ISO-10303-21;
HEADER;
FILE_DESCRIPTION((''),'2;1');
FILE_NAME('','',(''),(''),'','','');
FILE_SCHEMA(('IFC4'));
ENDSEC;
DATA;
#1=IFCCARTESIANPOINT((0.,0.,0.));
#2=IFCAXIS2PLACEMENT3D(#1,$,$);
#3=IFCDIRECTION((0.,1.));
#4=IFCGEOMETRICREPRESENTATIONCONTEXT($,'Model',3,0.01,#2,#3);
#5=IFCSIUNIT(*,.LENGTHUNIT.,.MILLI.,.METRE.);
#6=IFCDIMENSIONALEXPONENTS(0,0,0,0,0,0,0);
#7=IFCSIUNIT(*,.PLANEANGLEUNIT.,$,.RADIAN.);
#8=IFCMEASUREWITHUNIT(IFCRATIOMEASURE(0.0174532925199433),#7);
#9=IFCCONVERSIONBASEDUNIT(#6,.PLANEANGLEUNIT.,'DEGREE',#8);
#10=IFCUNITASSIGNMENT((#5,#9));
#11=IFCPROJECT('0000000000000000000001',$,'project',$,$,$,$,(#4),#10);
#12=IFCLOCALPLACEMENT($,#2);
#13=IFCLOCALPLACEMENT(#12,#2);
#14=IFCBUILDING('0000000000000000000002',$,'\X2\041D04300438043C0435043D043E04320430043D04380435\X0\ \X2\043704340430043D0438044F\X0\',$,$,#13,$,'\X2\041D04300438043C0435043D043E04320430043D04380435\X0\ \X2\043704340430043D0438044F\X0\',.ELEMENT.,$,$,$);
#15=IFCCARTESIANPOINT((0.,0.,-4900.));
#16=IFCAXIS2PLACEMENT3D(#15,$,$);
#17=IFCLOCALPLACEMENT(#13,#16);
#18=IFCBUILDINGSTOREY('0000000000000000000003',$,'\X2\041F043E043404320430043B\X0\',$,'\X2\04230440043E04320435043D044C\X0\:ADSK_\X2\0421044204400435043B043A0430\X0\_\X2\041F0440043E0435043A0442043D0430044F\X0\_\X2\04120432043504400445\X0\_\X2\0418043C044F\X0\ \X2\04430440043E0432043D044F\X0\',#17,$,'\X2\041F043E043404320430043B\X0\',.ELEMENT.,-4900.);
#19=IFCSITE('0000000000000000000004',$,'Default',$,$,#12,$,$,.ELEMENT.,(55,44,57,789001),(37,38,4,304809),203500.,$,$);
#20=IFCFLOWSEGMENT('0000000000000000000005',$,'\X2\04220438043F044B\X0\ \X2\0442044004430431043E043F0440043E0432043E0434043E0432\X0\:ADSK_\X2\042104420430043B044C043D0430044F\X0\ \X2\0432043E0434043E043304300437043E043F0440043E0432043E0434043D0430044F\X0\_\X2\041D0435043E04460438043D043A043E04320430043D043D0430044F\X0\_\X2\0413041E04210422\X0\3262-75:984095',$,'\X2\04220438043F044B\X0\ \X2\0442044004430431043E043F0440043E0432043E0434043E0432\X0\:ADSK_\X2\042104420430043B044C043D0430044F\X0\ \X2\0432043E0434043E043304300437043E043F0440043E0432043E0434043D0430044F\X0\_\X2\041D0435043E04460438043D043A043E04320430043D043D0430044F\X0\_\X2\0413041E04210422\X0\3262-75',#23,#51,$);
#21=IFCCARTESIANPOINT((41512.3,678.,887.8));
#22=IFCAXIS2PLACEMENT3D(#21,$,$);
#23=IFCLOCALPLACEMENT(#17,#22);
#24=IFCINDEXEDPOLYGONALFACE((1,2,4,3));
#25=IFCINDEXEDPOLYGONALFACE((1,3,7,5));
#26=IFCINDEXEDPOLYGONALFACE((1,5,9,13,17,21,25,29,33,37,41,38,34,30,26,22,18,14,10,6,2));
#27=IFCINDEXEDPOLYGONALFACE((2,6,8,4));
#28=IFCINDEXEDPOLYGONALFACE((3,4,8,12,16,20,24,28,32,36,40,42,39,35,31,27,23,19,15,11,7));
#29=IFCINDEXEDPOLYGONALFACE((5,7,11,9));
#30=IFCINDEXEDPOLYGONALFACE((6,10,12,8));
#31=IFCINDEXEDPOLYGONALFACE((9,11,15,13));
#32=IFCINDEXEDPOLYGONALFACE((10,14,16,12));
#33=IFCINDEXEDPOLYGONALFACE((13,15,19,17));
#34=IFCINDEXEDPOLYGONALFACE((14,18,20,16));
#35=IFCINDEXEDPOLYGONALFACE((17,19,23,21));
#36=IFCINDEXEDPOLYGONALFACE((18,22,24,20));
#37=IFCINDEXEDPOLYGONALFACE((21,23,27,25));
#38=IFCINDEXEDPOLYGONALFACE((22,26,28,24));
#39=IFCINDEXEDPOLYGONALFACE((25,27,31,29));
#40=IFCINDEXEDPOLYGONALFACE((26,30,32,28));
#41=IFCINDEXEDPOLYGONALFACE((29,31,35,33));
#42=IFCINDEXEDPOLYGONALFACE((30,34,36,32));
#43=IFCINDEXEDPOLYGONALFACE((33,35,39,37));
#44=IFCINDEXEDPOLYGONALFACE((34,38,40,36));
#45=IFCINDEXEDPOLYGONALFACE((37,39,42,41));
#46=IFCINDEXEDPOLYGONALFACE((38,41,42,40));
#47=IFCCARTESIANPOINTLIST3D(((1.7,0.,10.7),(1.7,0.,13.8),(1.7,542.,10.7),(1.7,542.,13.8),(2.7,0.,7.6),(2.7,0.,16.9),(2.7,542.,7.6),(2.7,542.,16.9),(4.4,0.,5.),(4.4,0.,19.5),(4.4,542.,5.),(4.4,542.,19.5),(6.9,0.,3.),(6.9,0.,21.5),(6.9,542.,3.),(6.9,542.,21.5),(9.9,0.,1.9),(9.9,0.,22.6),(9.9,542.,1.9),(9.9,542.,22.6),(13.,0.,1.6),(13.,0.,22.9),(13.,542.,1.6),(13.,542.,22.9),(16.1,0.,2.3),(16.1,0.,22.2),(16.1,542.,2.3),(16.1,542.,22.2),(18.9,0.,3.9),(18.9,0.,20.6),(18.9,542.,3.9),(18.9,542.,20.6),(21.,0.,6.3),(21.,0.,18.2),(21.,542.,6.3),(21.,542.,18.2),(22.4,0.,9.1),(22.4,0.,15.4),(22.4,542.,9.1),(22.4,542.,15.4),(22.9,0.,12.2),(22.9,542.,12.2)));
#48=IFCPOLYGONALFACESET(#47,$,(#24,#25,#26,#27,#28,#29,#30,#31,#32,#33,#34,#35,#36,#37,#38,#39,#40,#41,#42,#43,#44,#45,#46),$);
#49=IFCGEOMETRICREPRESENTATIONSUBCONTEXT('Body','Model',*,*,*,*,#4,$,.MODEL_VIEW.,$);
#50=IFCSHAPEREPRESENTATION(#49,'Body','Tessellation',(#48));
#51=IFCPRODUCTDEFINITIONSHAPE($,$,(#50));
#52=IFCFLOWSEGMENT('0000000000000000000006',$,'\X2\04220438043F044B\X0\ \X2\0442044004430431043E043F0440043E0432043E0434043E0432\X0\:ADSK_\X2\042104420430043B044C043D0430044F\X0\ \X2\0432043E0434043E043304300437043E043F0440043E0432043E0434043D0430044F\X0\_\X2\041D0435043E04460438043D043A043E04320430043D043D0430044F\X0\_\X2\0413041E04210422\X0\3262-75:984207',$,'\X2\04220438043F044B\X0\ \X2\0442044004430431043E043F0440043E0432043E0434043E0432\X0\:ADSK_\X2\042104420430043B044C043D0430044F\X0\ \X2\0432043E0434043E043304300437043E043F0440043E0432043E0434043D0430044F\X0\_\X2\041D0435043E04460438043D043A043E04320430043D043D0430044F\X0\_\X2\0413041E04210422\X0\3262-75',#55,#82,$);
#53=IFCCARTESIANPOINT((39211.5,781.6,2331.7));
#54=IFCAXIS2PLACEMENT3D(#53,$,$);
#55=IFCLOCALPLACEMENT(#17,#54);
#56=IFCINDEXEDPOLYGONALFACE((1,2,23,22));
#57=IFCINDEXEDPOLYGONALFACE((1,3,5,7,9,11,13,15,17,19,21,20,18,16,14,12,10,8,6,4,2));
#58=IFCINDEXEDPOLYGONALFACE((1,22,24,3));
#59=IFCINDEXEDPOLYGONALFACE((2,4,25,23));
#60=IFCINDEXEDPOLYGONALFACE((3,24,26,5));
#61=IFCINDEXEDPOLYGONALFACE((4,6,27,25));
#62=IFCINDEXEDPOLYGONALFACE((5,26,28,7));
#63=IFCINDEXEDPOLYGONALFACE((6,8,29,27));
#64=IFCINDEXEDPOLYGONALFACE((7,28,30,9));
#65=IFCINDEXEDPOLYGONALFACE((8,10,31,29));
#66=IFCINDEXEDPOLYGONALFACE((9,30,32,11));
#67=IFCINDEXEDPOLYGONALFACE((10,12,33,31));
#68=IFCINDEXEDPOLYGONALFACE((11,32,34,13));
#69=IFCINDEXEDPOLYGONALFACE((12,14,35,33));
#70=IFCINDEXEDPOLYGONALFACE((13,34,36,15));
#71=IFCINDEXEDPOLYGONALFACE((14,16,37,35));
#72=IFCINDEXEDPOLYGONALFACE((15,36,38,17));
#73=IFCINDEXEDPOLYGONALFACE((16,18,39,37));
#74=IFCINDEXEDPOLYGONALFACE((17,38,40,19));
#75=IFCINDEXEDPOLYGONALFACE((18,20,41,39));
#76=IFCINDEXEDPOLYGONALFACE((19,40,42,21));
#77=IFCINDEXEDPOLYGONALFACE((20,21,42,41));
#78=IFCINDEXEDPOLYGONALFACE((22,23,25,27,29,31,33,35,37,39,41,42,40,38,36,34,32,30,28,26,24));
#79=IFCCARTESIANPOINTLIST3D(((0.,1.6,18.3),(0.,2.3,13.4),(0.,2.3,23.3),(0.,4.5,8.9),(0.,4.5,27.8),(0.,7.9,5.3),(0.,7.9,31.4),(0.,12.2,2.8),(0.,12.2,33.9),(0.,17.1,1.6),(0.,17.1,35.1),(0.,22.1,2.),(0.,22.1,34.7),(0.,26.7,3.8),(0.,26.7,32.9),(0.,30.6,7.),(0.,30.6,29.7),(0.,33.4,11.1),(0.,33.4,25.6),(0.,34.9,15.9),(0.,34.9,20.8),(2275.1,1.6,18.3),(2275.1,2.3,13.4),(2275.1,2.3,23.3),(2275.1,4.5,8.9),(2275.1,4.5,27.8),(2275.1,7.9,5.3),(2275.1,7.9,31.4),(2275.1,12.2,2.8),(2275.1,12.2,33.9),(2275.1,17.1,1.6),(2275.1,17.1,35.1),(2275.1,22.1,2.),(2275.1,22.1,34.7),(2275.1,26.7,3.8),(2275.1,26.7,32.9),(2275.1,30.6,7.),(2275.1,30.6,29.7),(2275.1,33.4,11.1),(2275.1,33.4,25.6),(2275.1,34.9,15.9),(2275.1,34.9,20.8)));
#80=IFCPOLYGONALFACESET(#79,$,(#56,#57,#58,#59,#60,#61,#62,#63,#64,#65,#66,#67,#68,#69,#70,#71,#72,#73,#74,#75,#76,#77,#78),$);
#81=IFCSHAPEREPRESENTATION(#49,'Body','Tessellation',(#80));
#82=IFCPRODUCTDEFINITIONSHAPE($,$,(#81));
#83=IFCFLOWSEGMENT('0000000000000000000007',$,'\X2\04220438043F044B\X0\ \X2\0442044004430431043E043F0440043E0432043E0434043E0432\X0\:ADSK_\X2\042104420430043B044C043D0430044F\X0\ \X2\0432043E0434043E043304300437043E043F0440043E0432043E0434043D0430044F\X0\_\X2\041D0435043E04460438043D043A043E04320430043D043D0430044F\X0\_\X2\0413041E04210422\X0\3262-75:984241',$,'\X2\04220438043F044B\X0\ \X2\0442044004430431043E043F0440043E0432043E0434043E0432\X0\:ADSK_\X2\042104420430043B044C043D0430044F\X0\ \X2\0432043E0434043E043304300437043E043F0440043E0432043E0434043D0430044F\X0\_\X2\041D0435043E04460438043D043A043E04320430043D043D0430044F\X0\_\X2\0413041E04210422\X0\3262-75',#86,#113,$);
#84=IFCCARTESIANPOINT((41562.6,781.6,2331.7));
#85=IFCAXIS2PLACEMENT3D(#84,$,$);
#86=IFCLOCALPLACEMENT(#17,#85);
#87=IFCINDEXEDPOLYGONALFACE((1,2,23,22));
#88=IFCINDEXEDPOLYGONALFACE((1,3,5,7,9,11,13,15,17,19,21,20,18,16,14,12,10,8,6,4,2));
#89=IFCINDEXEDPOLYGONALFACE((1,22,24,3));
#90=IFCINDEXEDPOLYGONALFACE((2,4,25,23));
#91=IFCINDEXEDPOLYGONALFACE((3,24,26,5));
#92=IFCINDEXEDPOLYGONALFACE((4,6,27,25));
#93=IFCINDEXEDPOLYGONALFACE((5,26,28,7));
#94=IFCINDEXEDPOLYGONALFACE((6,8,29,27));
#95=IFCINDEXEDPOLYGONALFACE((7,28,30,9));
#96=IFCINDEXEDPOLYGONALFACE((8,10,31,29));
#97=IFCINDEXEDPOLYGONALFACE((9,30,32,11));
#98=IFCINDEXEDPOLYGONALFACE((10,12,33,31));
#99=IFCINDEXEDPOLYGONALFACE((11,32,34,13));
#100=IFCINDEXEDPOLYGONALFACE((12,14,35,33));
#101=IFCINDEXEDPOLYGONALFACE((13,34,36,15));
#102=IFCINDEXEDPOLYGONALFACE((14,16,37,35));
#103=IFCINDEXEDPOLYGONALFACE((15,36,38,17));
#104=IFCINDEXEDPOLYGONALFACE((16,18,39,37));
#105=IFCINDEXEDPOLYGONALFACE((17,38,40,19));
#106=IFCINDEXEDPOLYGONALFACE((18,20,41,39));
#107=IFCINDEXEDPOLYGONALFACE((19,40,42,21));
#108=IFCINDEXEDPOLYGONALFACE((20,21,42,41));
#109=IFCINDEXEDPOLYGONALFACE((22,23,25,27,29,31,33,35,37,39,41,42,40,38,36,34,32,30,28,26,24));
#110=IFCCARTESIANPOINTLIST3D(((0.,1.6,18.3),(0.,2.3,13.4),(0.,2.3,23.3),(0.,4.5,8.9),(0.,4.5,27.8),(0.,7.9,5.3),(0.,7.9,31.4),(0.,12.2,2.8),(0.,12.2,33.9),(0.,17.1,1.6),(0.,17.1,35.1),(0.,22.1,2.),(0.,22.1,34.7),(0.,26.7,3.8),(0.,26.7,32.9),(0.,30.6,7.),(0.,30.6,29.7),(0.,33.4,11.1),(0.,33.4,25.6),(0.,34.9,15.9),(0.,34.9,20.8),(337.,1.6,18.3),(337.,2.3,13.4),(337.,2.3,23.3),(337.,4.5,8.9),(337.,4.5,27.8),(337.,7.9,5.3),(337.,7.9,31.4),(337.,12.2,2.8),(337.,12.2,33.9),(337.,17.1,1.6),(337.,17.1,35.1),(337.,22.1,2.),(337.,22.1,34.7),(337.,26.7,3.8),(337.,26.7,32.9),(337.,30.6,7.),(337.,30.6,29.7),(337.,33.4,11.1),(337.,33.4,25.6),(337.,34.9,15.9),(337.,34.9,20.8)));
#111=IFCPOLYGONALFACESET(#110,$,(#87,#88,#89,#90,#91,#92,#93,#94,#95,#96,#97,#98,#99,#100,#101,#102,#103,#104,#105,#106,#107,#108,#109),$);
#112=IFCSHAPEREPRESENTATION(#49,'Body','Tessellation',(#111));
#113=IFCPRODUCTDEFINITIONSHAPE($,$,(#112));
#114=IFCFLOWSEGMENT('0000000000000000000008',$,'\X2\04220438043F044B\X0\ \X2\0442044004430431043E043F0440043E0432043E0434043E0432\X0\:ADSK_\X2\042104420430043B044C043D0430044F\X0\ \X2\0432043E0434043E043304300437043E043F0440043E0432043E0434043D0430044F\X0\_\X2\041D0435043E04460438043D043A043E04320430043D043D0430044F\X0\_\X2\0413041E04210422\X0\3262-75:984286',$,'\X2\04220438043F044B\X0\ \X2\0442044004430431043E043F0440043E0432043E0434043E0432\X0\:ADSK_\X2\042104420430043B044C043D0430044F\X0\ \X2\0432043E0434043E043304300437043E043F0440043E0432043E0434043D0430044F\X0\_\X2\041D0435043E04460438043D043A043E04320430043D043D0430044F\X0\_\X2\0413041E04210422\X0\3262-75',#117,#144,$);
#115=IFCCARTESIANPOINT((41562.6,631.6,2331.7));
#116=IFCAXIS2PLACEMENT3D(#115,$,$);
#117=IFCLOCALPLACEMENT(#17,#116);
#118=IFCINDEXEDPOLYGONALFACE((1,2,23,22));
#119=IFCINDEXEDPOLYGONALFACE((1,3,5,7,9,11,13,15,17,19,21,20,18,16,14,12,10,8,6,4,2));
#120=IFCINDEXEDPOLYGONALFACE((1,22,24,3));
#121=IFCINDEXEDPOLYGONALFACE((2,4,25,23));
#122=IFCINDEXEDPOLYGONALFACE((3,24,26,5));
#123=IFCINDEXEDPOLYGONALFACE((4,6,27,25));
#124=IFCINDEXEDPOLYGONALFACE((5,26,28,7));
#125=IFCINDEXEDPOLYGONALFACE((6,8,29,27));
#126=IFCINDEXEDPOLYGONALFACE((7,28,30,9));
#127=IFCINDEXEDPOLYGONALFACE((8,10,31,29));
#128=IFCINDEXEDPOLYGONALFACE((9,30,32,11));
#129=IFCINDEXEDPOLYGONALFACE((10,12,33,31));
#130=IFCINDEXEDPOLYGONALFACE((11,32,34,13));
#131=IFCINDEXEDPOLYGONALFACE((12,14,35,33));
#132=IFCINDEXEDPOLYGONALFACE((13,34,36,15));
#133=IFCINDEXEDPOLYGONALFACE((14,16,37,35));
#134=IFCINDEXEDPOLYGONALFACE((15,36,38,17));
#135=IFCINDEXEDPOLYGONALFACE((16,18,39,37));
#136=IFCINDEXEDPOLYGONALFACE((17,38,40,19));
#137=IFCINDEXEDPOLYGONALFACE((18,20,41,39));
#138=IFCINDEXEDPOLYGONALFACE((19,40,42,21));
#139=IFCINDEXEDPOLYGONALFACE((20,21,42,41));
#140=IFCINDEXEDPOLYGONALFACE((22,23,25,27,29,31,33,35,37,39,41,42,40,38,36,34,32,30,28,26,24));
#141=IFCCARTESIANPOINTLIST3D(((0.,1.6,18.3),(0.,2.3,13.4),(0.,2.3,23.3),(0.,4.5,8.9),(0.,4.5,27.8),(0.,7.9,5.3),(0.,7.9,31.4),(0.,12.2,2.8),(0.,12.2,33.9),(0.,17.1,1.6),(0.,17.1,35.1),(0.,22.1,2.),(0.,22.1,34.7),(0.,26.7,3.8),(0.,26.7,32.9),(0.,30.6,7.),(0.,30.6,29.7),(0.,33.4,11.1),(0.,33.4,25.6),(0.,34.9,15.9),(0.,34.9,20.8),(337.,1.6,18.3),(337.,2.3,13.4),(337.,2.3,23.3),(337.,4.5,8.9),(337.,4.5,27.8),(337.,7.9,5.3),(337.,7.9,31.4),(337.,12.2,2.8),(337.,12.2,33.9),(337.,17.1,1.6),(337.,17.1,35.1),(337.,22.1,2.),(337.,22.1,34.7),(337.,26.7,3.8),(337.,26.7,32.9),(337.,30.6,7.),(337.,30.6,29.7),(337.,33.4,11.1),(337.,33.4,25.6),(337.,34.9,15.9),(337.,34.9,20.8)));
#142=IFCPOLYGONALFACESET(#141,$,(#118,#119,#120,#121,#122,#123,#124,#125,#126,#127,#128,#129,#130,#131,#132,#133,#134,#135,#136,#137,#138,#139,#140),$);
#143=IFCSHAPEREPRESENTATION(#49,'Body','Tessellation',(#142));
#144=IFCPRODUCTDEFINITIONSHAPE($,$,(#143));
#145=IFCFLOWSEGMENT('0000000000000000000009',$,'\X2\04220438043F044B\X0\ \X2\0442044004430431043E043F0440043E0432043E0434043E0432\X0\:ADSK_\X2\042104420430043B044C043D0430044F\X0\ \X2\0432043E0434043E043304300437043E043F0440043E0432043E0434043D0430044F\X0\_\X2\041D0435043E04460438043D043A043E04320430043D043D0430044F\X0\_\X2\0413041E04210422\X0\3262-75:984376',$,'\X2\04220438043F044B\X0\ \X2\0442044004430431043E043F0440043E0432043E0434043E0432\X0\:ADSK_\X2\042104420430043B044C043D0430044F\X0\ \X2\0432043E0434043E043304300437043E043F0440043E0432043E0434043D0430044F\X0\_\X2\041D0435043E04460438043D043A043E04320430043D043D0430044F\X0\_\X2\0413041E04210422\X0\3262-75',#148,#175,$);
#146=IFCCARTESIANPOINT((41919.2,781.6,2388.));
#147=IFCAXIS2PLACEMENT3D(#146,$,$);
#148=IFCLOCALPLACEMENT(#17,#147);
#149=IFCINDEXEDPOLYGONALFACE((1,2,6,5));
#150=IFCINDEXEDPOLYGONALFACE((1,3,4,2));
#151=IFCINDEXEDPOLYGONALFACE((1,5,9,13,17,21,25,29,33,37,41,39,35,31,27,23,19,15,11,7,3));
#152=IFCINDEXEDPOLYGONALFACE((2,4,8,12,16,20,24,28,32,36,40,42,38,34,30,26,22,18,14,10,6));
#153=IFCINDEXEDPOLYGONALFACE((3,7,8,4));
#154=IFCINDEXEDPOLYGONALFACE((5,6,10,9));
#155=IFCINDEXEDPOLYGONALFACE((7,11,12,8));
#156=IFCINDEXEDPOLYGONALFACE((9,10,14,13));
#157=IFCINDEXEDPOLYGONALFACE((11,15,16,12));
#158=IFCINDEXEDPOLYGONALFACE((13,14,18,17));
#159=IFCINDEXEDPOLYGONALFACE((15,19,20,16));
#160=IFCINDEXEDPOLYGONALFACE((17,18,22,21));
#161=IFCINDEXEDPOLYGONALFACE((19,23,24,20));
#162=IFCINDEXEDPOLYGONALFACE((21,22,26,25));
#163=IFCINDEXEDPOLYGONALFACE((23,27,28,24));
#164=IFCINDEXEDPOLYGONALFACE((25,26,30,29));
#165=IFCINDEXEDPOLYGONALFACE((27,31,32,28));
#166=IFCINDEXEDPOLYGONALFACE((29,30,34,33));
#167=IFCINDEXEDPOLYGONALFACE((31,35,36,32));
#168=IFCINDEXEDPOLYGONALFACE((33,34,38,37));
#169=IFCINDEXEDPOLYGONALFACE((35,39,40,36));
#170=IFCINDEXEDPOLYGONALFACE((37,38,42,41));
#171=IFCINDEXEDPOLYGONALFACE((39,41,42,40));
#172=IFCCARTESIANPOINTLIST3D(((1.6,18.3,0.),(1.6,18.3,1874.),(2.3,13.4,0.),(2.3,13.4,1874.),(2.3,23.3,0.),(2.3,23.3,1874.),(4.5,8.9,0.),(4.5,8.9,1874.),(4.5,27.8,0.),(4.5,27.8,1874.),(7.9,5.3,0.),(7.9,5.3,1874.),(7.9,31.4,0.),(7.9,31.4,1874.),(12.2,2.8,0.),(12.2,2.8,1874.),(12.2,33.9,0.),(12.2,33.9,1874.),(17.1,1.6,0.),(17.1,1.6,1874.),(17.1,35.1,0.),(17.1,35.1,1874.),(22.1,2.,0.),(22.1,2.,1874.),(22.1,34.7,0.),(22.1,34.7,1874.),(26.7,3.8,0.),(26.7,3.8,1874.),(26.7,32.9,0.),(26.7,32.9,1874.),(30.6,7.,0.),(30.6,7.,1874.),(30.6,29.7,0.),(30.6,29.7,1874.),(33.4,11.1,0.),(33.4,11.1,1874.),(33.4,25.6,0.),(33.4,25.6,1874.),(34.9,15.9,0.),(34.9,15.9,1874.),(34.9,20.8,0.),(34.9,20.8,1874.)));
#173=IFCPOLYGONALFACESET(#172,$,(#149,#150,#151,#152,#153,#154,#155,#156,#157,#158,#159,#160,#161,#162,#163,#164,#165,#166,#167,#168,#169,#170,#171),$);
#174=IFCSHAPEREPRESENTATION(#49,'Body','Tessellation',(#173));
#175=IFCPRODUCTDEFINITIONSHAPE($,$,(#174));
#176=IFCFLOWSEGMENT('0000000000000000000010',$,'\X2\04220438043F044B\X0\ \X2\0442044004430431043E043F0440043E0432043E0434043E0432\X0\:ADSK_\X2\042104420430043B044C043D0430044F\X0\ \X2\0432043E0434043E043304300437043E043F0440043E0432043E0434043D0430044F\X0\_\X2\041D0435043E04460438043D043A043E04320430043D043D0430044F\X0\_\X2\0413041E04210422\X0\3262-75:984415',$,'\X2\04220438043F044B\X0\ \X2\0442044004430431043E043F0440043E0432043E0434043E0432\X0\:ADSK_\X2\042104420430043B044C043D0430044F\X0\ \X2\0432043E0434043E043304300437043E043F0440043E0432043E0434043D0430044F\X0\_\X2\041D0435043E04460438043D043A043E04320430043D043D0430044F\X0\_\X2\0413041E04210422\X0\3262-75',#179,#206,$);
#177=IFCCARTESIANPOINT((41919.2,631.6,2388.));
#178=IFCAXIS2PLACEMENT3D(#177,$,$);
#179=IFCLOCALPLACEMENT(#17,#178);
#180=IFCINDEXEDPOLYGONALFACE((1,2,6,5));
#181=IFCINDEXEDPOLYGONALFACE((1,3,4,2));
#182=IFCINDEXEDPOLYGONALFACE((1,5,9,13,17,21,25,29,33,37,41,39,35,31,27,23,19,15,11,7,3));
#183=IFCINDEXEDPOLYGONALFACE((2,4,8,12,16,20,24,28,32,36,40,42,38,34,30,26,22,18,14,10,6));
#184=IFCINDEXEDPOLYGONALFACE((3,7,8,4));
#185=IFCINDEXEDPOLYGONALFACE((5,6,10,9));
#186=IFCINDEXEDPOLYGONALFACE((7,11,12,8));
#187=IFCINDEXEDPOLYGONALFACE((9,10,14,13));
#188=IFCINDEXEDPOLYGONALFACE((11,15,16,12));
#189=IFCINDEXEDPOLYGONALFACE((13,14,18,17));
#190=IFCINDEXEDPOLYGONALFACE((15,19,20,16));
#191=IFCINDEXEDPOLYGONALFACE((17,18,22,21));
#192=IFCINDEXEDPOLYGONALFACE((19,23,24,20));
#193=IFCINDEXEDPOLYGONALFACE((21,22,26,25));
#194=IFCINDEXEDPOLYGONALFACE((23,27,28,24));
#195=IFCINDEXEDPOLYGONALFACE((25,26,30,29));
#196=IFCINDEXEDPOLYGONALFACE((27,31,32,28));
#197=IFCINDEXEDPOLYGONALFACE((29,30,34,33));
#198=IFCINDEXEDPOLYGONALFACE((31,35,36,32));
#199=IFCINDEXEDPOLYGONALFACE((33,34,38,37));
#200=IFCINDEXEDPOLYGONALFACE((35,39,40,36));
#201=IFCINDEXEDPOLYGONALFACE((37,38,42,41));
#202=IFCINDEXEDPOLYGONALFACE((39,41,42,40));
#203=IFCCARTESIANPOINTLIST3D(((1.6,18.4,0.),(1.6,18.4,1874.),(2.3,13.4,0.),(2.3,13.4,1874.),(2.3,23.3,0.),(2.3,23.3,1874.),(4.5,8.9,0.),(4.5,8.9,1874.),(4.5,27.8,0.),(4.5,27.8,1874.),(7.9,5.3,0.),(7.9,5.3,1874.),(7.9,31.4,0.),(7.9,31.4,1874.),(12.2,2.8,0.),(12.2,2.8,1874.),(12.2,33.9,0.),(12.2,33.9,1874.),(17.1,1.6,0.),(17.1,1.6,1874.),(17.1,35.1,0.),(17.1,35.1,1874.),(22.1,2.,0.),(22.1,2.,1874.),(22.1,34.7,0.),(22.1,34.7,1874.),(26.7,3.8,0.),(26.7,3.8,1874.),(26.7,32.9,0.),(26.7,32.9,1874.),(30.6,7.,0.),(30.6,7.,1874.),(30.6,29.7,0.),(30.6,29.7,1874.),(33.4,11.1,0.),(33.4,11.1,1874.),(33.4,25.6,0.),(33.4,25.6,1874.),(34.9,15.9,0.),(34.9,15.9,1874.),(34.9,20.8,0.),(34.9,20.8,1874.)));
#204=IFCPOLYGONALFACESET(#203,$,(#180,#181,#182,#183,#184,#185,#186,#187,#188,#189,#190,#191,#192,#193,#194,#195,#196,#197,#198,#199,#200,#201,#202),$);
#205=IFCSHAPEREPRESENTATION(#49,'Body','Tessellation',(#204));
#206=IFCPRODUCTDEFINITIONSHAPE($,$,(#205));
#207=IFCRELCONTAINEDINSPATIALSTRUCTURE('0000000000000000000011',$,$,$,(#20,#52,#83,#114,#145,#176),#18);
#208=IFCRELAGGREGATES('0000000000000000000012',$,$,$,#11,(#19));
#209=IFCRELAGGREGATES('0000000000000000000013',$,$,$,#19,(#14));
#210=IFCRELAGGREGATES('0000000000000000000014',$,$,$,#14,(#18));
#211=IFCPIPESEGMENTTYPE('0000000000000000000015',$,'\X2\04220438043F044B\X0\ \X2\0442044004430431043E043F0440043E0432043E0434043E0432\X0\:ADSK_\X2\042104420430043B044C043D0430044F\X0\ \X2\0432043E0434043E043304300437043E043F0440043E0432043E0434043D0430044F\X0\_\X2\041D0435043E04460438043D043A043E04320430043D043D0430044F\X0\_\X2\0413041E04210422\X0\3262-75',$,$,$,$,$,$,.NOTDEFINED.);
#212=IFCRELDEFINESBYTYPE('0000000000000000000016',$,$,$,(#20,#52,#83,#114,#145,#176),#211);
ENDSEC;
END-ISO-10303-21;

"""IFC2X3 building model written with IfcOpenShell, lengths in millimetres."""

from ifc_helpers import new_model, entity, si_unit, converted_unit, direction, frame, origin, origin_2d_with_axis, place, context, subcontext, project, spatial, circle, extrude, type_object, element, save


model = new_model("IFC2X3")

# Units and contexts
model_context = context("Model", 3, precision=0.01, world=origin(), true_north=direction((0.0, 1.0)))
body_context = subcontext(model_context, "Body", "Model", "MODEL_VIEW")
ifc_project = project(units=[si_unit("LENGTHUNIT", "METRE", prefix="MILLI"), converted_unit("PLANEANGLEUNIT", "DEGREE", entity("IfcRatioMeasure", 0.0174532925199433), si_unit("PLANEANGLEUNIT", "RADIAN"), dimensions=[0, 0, 0, 0, 0, 0, 0])], contexts=[model_context])

# Site, building, storey
site_placement = place(None, origin())
site = spatial("IfcSite", under=ifc_project, at=site_placement, Name="Default", CompositionType="ELEMENT", RefLatitude=(55, 44, 57, 789001), RefLongitude=(37, 38, 4, 304809), RefElevation=203500.0)
building_placement = place(site_placement, origin())
building = spatial("IfcBuilding", under=site, at=building_placement, Name="Наименование здания", LongName="Наименование здания", CompositionType="ELEMENT")
storey_placement = place(building_placement, frame((0.0, 0.0, -4900.0)))
storey = spatial("IfcBuildingStorey", under=building, at=storey_placement, Name="Подвал", ObjectType="Уровень:ADSK_Стрелка_Проектная_Вверх_Имя уровня", LongName="Подвал", CompositionType="ELEMENT", Elevation=-4900.0)

# Flow segments
pipe_segment_type = type_object("IfcPipeSegmentType", Name="Типы трубопроводов:ADSK_Стальная водогазопроводная_Неоцинкованная_ГОСТ3262-75", PredefinedType="NOTDEFINED")
flow_segment_1_placement = place(storey_placement, frame((41512.3, 678.0, 887.8)))
element("IfcFlowSegment", 1, at=flow_segment_1_placement, inside=storey, type_object=pipe_segment_type, Name="Типы трубопроводов:ADSK_Стальная водогазопроводная_Неоцинкованная_ГОСТ3262-75:984095", ObjectType="Типы трубопроводов:ADSK_Стальная водогазопроводная_Неоцинкованная_ГОСТ3262-75", context=body_context, shape_type="SweptSolid", body=[
    extrude(circle(Radius=10.7, at=origin_2d_with_axis()), frame((12.2, 0.0, 12.2), z_axis=(0.0, 1.0, 0.0), x_axis=(1.0, 0.0, 0.0)), (0.0, 0.0, 1.0), 542.0),
])
flow_segment_2_placement = place(storey_placement, frame((39211.5, 781.6, 2331.7)))
element("IfcFlowSegment", 2, at=flow_segment_2_placement, inside=storey, type_object=pipe_segment_type, Name="Типы трубопроводов:ADSK_Стальная водогазопроводная_Неоцинкованная_ГОСТ3262-75:984207", ObjectType="Типы трубопроводов:ADSK_Стальная водогазопроводная_Неоцинкованная_ГОСТ3262-75", context=body_context, shape_type="SweptSolid", body=[
    extrude(circle(Radius=16.8, at=origin_2d_with_axis()), frame((0.0, 18.4, 18.4), z_axis=(1.0, 0.0, 0.0), x_axis=(0.0, -1.0, 0.0)), (0.0, 0.0, 1.0), 2275.1),
])
for number, where, name in (
    (3, (41562.6, 781.6, 2331.7), "Типы трубопроводов:ADSK_Стальная водогазопроводная_Неоцинкованная_ГОСТ3262-75:984241"),
    (4, (41562.6, 631.6, 2331.7), "Типы трубопроводов:ADSK_Стальная водогазопроводная_Неоцинкованная_ГОСТ3262-75:984286"),
):
    element("IfcFlowSegment", number, at=place(storey_placement, frame(where)), inside=storey, type_object=pipe_segment_type, Name=name, ObjectType="Типы трубопроводов:ADSK_Стальная водогазопроводная_Неоцинкованная_ГОСТ3262-75", context=body_context, shape_type="SweptSolid", body=[
        extrude(circle(Radius=16.8, at=origin_2d_with_axis()), frame((0.0, 18.4, 18.4), z_axis=(1.0, 0.0, 0.0), x_axis=(0.0, -1.0, 0.0)), (0.0, 0.0, 1.0), 337.0),
    ])
flow_segment_3_placement = place(storey_placement, frame((41919.2, 781.6, 2388.0)))
element("IfcFlowSegment", 5, at=flow_segment_3_placement, inside=storey, type_object=pipe_segment_type, Name="Типы трубопроводов:ADSK_Стальная водогазопроводная_Неоцинкованная_ГОСТ3262-75:984376", ObjectType="Типы трубопроводов:ADSK_Стальная водогазопроводная_Неоцинкованная_ГОСТ3262-75", context=body_context, shape_type="SweptSolid", body=[
    extrude(circle(Radius=16.8, at=origin_2d_with_axis()), frame((18.4, 18.4, 0.0), z_axis=(0.0, 0.0, 1.0), x_axis=(-1.0, 0.0, 0.0)), (0.0, 0.0, 1.0), 1874.0),
])
flow_segment_4_placement = place(storey_placement, frame((41919.2, 631.6, 2388.0)))
element("IfcFlowSegment", 6, at=flow_segment_4_placement, inside=storey, type_object=pipe_segment_type, Name="Типы трубопроводов:ADSK_Стальная водогазопроводная_Неоцинкованная_ГОСТ3262-75:984415", ObjectType="Типы трубопроводов:ADSK_Стальная водогазопроводная_Неоцинкованная_ГОСТ3262-75", context=body_context, shape_type="SweptSolid", body=[
    extrude(circle(Radius=16.8, at=origin_2d_with_axis()), frame((18.4, 18.4, 0.0), z_axis=(0.0, 0.0, 1.0), x_axis=(-1.0, 0.0, 0.0)), (0.0, 0.0, 1.0), 1874.0),
])

save(model, "model.ifc")
